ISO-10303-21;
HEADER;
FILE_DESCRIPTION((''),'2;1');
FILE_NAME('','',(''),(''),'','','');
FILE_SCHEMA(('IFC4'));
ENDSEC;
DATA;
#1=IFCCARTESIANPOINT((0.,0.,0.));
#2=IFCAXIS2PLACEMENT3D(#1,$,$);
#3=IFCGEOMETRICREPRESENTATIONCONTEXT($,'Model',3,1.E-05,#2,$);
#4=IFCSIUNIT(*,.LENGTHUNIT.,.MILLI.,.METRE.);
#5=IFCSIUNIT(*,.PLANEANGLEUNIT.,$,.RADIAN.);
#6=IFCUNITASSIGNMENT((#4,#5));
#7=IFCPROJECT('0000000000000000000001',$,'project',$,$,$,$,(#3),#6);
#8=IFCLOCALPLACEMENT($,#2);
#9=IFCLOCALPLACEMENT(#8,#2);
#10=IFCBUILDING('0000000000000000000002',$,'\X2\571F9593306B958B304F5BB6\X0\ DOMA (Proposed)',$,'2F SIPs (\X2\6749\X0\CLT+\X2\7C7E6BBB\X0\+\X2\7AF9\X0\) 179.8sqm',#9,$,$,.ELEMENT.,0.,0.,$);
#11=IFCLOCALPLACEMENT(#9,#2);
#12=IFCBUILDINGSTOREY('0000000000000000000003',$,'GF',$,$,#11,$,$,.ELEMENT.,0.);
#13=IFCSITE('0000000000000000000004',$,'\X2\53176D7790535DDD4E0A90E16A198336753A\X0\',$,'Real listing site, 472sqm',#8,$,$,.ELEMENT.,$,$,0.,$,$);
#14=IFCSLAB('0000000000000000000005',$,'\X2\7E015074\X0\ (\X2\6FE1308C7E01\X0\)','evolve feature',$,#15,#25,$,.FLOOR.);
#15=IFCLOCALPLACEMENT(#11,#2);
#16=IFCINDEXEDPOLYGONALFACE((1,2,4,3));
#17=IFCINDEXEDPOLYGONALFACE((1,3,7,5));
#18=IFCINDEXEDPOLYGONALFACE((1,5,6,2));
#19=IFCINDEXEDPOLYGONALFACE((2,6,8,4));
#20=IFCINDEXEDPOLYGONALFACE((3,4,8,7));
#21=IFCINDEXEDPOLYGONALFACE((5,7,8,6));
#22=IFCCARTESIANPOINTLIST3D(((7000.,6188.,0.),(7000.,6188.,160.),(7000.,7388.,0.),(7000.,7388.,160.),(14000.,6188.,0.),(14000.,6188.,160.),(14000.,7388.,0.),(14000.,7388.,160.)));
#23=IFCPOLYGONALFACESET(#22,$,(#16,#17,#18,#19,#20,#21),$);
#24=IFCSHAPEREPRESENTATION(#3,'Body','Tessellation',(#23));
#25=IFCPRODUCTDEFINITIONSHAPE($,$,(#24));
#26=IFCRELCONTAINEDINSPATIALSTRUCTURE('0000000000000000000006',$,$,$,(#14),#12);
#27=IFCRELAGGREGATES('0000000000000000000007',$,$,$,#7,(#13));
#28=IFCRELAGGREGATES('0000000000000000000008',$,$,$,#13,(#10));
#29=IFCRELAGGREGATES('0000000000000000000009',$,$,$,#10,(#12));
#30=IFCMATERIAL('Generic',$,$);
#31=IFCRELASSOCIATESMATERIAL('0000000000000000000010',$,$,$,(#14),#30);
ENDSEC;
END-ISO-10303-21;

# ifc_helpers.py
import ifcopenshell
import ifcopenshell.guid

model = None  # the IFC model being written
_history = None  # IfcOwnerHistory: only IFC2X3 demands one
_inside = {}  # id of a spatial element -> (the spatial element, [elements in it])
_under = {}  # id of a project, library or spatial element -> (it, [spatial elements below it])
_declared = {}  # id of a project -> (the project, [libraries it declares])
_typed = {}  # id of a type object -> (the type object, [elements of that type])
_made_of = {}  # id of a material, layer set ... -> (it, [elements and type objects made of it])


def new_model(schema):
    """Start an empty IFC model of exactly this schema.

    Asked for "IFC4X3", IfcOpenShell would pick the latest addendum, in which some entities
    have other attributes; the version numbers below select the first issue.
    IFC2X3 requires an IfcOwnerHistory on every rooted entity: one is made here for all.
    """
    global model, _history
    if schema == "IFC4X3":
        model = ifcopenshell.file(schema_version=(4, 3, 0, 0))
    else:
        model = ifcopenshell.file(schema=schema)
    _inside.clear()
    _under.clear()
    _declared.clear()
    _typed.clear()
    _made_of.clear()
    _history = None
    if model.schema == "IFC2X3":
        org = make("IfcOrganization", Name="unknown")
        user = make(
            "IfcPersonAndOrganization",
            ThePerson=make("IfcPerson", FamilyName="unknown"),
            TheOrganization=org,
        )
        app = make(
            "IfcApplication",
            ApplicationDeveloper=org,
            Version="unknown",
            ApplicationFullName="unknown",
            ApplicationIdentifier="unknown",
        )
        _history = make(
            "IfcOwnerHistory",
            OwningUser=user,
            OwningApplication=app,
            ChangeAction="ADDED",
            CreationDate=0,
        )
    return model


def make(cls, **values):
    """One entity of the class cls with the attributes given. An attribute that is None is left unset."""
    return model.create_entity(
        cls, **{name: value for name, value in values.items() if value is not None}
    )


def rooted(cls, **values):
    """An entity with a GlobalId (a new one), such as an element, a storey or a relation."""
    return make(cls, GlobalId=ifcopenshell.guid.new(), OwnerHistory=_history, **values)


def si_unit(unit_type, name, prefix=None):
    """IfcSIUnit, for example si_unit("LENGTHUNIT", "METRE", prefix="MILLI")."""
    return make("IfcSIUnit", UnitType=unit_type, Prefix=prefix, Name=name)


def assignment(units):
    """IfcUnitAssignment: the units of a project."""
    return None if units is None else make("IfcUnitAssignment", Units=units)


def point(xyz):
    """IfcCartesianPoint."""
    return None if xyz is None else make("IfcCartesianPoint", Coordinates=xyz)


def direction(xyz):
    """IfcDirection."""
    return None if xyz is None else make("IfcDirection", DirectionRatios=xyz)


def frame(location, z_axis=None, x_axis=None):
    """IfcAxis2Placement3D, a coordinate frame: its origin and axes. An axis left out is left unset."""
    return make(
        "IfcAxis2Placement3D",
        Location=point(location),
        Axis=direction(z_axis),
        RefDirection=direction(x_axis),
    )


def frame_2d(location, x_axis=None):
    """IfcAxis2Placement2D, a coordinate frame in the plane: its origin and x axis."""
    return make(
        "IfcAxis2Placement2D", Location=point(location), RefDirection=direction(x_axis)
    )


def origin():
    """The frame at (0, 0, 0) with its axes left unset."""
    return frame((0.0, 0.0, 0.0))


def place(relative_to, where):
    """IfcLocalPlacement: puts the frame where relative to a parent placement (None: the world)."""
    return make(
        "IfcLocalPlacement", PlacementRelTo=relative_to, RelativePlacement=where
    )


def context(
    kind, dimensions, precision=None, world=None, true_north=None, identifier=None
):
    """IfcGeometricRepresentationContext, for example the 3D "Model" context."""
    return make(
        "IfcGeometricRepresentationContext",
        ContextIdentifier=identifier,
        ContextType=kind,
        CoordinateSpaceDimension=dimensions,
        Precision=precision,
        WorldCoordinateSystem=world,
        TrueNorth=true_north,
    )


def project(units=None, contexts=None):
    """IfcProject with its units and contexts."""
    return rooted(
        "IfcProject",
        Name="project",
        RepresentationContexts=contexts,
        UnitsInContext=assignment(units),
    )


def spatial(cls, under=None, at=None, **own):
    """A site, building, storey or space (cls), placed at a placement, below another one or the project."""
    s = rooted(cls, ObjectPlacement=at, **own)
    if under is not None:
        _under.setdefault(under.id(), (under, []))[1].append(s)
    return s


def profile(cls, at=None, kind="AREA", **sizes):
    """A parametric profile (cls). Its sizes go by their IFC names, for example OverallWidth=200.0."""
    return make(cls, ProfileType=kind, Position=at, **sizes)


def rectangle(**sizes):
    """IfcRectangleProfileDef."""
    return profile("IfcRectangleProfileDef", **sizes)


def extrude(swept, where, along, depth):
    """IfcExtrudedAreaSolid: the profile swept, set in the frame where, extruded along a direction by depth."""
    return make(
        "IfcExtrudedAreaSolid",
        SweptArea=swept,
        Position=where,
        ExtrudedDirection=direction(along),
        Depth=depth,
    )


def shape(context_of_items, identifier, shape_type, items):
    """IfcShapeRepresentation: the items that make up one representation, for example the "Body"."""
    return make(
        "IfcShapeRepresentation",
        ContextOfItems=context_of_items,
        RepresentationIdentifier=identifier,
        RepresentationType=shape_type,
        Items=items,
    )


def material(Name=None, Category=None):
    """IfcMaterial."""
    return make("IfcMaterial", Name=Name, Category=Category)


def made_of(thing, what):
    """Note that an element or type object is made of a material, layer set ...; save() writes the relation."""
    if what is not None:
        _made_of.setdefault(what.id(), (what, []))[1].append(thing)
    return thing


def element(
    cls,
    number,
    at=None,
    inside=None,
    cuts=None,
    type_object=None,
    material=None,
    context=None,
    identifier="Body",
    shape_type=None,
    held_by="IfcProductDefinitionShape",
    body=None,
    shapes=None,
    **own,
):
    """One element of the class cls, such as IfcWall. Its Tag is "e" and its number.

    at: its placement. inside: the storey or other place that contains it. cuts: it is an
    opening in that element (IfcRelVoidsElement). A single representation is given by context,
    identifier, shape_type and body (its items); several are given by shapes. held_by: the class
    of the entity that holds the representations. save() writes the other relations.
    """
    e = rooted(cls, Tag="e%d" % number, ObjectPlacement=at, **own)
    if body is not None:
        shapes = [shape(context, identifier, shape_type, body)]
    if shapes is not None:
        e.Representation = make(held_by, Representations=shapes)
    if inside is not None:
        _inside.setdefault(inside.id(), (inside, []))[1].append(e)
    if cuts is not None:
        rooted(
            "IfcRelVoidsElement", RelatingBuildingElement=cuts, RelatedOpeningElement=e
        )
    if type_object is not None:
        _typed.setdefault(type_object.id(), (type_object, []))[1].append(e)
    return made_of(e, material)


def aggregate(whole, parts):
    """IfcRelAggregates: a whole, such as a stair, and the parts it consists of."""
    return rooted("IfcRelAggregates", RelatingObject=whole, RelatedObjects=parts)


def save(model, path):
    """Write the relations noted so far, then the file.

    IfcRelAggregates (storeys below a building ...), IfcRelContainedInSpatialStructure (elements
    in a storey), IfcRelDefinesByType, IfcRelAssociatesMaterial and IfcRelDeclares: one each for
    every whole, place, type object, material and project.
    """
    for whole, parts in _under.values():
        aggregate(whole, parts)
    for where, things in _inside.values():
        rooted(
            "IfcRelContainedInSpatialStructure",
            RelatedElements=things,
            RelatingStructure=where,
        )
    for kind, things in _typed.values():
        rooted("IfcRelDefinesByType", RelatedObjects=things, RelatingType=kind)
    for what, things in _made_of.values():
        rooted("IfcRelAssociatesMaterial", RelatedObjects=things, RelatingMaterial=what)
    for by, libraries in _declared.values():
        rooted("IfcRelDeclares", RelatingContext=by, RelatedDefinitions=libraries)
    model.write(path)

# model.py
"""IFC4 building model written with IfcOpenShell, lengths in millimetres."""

from ifc_helpers import new_model, si_unit, frame, frame_2d, origin, place, context, project, spatial, rectangle, extrude, material, element, save


model = new_model("IFC4")

# Units and contexts
model_context = context("Model", 3, precision=1e-05, world=origin())
ifc_project = project(units=[si_unit("LENGTHUNIT", "METRE", prefix="MILLI"), si_unit("PLANEANGLEUNIT", "RADIAN")], contexts=[model_context])

# Site, building, storey
site_placement = place(None, origin())
site = spatial("IfcSite", under=ifc_project, at=site_placement, Name="北海道川上郡標茶町", ObjectType="Real listing site, 472sqm", CompositionType="ELEMENT", RefElevation=0.0)
building_placement = place(site_placement, origin())
building = spatial("IfcBuilding", under=site, at=building_placement, Name="土間に開く家 DOMA (Proposed)", ObjectType="2F SIPs (杉CLT+籾殻+竹) 179.8sqm", CompositionType="ELEMENT", ElevationOfRefHeight=0.0, ElevationOfTerrain=0.0)
storey_placement = place(building_placement, origin())
storey = spatial("IfcBuildingStorey", under=building, at=storey_placement, Name="GF", CompositionType="ELEMENT", Elevation=0.0)

# Slab
ifc_material_1 = material(Name="Generic")
slab_1_placement = place(storey_placement, frame((3500.0, 3094.0, 0.0)))
element("IfcSlab", 1, at=slab_1_placement, inside=storey, material=ifc_material_1, Name="縁側 (濡れ縁)", Description="evolve feature", PredefinedType="FLOOR", context=model_context, shape_type="SweptSolid", body=[
    extrude(rectangle(XDim=7000.0, YDim=1200.0, at=frame_2d((3500.0, 600.0))), frame((3500.0, 3094.0, 0.0)), (0.0, 0.0, 1.0), 160.0),
])

save(model, "model.ifc")
